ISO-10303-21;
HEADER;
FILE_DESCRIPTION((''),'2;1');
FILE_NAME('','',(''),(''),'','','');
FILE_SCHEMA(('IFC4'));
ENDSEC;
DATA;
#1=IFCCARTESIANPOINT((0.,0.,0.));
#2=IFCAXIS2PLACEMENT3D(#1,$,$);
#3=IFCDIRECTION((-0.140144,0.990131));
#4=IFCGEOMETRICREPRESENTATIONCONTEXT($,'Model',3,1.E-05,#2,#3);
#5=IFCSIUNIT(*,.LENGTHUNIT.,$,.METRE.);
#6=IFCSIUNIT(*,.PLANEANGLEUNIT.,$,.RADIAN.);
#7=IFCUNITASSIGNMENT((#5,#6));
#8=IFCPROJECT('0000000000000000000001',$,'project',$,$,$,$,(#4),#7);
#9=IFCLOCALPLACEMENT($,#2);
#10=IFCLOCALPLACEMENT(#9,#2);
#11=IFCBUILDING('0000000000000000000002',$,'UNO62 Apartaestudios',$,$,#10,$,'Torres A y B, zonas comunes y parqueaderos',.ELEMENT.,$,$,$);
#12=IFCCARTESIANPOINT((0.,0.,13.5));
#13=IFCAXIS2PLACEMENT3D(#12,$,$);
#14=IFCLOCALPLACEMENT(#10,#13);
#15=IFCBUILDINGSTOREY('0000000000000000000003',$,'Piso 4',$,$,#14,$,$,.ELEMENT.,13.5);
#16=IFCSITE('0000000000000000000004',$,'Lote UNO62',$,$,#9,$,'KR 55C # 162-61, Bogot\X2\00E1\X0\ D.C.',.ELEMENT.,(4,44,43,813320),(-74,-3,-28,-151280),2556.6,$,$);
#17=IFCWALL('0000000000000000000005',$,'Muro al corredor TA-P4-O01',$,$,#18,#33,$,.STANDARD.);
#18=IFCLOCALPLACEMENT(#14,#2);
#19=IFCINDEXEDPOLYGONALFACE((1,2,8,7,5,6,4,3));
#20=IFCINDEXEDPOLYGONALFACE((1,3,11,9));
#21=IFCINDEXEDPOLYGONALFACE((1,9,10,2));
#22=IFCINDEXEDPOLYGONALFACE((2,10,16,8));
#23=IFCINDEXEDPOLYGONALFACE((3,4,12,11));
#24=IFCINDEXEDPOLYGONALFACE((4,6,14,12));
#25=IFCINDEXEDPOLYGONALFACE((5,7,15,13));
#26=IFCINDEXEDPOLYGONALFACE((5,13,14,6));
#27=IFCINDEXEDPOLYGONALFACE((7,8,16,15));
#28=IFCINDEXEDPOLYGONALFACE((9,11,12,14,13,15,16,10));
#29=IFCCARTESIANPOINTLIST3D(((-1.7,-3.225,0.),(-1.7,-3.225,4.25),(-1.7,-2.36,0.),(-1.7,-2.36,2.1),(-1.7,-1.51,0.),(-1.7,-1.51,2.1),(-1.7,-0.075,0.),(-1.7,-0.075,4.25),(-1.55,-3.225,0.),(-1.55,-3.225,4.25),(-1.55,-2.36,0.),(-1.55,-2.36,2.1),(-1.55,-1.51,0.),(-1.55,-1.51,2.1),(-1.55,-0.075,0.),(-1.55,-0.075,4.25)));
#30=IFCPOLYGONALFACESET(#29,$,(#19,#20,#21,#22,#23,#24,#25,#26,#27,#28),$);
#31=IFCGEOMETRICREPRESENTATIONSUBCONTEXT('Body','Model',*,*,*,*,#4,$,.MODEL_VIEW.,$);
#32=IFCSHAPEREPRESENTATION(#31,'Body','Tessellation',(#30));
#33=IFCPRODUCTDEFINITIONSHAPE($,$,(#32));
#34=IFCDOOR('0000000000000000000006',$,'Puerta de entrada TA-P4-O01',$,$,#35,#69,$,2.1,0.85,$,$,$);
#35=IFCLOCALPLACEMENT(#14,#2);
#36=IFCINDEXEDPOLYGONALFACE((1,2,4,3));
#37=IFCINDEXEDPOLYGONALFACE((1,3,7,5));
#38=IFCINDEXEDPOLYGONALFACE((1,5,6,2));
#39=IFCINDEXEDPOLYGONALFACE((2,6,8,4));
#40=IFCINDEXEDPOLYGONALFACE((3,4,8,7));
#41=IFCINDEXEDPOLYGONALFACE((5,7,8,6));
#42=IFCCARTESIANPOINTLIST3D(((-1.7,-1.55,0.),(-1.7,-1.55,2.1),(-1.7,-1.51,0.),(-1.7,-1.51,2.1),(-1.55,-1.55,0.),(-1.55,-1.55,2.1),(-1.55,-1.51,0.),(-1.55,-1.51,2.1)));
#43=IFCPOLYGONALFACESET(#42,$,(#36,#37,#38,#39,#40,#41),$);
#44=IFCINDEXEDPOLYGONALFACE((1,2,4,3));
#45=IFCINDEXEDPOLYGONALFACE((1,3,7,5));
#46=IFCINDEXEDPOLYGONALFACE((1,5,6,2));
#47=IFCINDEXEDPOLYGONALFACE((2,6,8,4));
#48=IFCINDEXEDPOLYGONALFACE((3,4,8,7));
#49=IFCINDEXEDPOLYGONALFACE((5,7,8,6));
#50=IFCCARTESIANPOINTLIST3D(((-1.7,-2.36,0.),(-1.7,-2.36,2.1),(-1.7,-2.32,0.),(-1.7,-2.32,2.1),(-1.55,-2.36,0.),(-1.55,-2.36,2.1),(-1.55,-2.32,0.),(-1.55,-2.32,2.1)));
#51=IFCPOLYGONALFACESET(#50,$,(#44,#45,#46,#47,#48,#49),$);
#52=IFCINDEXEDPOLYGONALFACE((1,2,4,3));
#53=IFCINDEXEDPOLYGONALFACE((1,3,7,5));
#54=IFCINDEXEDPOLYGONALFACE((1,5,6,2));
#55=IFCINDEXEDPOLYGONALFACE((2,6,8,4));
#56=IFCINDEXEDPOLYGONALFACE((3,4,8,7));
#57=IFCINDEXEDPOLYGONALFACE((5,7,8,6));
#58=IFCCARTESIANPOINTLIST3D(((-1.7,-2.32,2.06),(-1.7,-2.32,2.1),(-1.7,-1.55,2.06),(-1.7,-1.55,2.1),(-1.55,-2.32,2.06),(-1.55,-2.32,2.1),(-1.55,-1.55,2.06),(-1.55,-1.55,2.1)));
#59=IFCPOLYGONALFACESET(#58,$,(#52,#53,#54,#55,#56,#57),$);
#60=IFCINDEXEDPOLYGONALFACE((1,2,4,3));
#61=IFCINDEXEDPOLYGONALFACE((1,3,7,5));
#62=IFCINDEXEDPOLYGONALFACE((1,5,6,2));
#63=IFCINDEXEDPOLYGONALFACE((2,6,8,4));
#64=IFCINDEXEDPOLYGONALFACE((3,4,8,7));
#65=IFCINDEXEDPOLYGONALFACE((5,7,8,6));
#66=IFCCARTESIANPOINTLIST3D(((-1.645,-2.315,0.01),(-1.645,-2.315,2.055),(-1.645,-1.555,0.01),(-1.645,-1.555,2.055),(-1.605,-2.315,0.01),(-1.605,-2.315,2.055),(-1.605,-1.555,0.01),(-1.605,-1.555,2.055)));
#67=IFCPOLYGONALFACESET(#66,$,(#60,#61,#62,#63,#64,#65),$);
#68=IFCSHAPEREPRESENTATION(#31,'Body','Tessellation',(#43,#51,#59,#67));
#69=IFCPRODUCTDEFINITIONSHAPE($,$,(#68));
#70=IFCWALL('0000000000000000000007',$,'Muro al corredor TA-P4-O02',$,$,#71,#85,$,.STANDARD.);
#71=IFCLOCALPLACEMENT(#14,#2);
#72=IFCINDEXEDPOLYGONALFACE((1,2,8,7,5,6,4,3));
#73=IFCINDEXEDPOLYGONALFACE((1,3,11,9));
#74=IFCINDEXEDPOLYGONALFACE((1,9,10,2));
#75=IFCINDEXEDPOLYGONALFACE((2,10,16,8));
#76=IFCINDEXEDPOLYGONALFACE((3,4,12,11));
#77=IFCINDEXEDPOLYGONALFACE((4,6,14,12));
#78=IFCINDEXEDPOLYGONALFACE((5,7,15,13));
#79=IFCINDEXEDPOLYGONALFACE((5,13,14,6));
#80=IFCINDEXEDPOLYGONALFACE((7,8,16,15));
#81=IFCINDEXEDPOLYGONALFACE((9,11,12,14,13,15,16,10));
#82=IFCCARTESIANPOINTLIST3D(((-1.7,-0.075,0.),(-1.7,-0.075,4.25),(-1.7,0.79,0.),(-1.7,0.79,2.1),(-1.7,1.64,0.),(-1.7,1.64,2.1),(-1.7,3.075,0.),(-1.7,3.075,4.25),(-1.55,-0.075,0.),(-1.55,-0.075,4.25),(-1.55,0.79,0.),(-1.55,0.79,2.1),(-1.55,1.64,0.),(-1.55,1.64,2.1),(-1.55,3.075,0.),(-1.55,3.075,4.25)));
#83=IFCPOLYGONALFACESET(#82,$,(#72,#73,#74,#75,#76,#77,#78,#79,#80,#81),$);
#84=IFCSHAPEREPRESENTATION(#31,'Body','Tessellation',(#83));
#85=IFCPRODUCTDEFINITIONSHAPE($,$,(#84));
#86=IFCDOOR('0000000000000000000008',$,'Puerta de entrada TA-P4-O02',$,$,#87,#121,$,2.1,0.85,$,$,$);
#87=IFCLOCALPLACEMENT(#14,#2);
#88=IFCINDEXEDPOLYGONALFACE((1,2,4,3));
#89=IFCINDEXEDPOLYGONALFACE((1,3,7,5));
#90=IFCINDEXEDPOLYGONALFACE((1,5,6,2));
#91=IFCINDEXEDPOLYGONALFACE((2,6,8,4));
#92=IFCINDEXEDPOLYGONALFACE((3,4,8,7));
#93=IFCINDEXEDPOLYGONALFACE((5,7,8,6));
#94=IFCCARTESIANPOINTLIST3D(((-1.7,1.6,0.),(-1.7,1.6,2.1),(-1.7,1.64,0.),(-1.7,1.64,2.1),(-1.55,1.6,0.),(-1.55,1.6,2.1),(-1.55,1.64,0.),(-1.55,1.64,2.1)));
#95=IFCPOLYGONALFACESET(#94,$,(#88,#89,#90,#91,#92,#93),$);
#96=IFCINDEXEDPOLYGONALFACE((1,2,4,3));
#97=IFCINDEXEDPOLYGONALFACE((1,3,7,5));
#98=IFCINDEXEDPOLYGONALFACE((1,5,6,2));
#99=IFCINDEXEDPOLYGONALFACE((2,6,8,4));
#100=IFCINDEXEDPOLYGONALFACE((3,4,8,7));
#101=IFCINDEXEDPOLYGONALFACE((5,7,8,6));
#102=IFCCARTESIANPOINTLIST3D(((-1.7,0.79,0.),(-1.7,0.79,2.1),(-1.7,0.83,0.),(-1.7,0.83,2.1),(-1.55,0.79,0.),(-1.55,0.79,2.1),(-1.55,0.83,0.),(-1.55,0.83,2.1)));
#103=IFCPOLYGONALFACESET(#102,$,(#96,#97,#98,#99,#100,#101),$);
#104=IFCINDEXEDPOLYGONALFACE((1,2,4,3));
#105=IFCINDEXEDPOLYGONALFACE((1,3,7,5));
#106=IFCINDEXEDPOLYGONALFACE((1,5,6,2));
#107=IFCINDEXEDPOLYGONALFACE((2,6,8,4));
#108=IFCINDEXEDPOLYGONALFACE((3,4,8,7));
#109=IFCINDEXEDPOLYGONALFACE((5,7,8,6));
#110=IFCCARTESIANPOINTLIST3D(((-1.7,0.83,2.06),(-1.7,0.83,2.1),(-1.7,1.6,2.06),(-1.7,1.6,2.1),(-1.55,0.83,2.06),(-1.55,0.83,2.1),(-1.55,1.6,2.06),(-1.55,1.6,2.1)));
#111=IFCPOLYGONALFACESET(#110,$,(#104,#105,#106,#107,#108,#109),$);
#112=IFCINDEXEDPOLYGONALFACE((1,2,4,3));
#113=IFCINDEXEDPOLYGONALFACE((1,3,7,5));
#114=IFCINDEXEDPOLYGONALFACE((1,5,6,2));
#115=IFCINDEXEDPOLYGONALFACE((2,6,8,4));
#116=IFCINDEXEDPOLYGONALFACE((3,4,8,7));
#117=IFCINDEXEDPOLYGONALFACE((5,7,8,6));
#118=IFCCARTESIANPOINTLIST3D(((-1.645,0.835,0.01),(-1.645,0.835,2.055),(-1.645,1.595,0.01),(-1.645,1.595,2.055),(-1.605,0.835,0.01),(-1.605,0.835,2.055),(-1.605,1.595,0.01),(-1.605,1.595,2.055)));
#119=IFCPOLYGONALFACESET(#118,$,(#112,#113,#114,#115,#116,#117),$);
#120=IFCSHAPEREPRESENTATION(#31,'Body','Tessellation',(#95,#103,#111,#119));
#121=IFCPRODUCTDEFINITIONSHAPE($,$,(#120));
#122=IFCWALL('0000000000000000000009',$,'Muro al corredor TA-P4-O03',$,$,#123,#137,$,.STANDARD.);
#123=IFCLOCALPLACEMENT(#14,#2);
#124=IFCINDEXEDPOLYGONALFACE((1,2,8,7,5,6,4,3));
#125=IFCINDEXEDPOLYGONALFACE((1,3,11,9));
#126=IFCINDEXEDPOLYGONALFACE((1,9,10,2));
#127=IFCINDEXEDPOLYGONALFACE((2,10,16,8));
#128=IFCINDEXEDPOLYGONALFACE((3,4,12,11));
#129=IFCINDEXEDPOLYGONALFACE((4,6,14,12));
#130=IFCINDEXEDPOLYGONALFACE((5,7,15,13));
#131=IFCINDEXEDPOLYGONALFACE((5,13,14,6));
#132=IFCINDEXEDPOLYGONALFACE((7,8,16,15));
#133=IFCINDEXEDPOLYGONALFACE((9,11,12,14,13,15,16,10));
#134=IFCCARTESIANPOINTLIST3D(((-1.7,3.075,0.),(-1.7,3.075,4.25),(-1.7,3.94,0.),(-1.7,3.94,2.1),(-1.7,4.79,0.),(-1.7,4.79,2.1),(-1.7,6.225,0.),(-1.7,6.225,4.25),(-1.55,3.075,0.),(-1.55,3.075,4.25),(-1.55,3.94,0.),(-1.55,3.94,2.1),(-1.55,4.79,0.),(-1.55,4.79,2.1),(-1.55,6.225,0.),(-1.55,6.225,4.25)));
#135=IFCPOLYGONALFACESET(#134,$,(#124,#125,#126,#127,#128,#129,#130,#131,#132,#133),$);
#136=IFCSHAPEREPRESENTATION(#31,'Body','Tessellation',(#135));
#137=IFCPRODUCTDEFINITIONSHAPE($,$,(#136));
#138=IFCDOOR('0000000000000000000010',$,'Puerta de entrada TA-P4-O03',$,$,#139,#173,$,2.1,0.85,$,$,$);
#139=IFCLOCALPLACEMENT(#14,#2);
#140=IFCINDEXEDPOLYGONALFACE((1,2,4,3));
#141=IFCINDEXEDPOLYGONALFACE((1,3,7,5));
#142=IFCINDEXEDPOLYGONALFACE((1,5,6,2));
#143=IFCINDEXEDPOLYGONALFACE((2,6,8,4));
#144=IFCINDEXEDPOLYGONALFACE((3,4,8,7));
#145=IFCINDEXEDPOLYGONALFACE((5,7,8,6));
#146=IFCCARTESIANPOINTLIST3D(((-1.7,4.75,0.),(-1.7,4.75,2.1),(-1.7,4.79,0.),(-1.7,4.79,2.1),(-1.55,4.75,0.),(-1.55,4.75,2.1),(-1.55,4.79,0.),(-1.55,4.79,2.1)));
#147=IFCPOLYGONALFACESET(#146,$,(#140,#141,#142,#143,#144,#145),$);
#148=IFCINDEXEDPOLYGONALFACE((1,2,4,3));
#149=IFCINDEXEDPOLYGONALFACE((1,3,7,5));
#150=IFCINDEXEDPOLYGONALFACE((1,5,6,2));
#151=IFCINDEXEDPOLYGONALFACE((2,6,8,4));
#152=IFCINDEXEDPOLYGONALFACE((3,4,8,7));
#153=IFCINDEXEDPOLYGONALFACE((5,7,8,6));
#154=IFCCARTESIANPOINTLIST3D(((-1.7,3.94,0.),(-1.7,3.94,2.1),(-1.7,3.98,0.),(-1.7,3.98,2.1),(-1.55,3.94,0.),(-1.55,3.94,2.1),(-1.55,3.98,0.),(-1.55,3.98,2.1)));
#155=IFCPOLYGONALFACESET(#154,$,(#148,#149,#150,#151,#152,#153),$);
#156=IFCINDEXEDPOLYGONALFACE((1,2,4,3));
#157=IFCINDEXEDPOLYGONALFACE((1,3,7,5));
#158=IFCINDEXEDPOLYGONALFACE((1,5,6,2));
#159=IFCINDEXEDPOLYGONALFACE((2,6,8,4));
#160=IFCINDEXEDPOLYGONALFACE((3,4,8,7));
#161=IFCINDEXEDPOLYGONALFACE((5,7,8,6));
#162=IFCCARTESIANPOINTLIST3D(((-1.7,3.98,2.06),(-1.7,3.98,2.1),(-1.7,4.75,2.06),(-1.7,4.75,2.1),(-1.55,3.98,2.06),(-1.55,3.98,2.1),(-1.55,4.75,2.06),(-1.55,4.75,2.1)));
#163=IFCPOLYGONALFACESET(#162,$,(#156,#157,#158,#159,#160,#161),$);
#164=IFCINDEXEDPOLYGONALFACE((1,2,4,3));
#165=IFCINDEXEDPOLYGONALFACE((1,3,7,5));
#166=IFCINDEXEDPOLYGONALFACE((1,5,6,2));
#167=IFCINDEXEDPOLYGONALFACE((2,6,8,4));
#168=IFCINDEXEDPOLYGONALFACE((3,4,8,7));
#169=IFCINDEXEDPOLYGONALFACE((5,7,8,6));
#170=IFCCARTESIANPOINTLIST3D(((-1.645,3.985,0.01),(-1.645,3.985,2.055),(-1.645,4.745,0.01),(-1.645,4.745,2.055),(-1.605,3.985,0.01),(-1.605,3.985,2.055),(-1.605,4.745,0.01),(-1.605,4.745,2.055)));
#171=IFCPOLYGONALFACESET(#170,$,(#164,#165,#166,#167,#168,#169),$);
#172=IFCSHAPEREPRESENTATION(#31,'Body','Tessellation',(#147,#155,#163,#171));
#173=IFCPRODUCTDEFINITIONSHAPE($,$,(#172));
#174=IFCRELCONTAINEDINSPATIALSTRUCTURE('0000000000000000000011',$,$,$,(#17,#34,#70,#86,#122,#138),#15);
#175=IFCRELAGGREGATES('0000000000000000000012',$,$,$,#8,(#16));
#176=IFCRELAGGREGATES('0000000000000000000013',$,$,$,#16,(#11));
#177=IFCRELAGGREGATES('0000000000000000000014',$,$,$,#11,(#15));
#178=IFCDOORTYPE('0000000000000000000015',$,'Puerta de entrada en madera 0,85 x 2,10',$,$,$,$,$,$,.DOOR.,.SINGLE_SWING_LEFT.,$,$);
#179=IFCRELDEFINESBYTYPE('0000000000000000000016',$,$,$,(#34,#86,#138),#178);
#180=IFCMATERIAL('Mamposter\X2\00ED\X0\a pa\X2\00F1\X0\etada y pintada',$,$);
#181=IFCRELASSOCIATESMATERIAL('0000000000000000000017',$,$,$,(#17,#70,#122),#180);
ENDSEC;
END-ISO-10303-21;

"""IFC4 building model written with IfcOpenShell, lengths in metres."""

from ifc_helpers import new_model, si_unit, direction, frame, frame_2d, origin, place, context, subcontext, project, spatial, rectangle, extrude, source, transform, mapped, material, type_object, type_shapes, element, fill, save


model = new_model("IFC4")

# Units and contexts
model_context = context("Model", 3, precision=1e-05, world=origin(), true_north=direction((-0.140144, 0.990131)))
body_context = subcontext(model_context, "Body", "Model", "MODEL_VIEW")
ifc_project = project(units=[si_unit("LENGTHUNIT", "METRE"), si_unit("PLANEANGLEUNIT", "RADIAN")], contexts=[model_context])

# Site, building, storey
site_placement = place(None, origin())
site = spatial("IfcSite", under=ifc_project, at=site_placement, Name="Lote UNO62", LongName="KR 55C # 162-61, Bogotá D.C.", CompositionType="ELEMENT", RefLatitude=(4, 44, 43, 813320), RefLongitude=(-74, -3, -28, -151280), RefElevation=2556.6)
building_placement = place(site_placement, origin())
building = spatial("IfcBuilding", under=site, at=building_placement, Name="UNO62 Apartaestudios", LongName="Torres A y B, zonas comunes y parqueaderos", CompositionType="ELEMENT")
storey_placement = place(building_placement, frame((0.0, 0.0, 13.5)))
storey = spatial("IfcBuildingStorey", under=building, at=storey_placement, Name="Piso 4", CompositionType="ELEMENT", Elevation=13.5)

# Walls, openings, doors
ifc_material = material(Name="Mampostería pañetada y pintada")
wall_1_placement = place(storey_placement, origin())
wall_1 = element("IfcWall", 1, at=wall_1_placement, inside=storey, material=ifc_material, Name="Muro al corredor TA-P4-O01", PredefinedType="STANDARD", context=body_context, shape_type="SweptSolid", body=[
    extrude(rectangle(XDim=0.15, YDim=3.15, at=frame_2d((-1.625, -1.65))), origin(), (0.0, 0.0, 1.0), 4.25),
])
opening_1_placement = place(wall_1_placement, origin())
opening_1 = element("IfcOpeningElement", 2, at=opening_1_placement, cuts=wall_1, PredefinedType="OPENING", context=body_context, shape_type="SweptSolid", body=[
    extrude(rectangle(XDim=0.25, YDim=0.85, at=frame_2d((-1.625, -1.935))), origin(), (0.0, 0.0, 1.0), 2.1),
])
door_type = type_object("IfcDoorType", Name="Puerta de entrada en madera 0,85 x 2,10", OperationType="SINGLE_SWING_LEFT", PredefinedType="DOOR")
shared_shape = source(origin(), body_context, "Body", "SweptSolid", [
    extrude(rectangle(XDim=0.15, YDim=0.04, at=frame_2d((-0.075, 1.38))), origin(), (0.0, 0.0, 1.0), 2.1),
    extrude(rectangle(XDim=0.15, YDim=0.04, at=frame_2d((-0.075, 2.19))), origin(), (0.0, 0.0, 1.0), 2.1),
    extrude(rectangle(XDim=0.15, YDim=0.77, at=frame_2d((-0.075, 1.785))), frame((0.0, 0.0, 2.06)), (0.0, 0.0, 1.0), 0.04),
    extrude(rectangle(XDim=0.04, YDim=0.76, at=frame_2d((-0.075, 1.785))), frame((0.0, 0.0, 0.01)), (0.0, 0.0, 1.0), 2.045),
])
type_shapes(door_type, [shared_shape])
placement_1 = place(storey_placement, frame((-1.7, -0.15, 0.0), z_axis=(0.0, 0.0, 1.0), x_axis=(-1.0, 0.0, 0.0)))
door_1_placement = place(placement_1, origin())
door_1 = element("IfcDoor", 3, at=door_1_placement, inside=storey, type_object=door_type, Name="Puerta de entrada TA-P4-O01", OverallHeight=2.1, OverallWidth=0.85, context=body_context, shape_type="MappedRepresentation", body=[
    mapped(shared_shape, transform((0.0, 0.0, 0.0))),
])
fill(opening_1, door_1)
wall_2_placement = place(storey_placement, origin())
wall_2 = element("IfcWall", 4, at=wall_2_placement, inside=storey, material=ifc_material, Name="Muro al corredor TA-P4-O02", PredefinedType="STANDARD", context=body_context, shape_type="SweptSolid", body=[
    extrude(rectangle(XDim=0.15, YDim=3.15, at=frame_2d((-1.625, 1.5))), origin(), (0.0, 0.0, 1.0), 4.25),
])
opening_2_placement = place(wall_2_placement, origin())
opening_2 = element("IfcOpeningElement", 5, at=opening_2_placement, cuts=wall_2, PredefinedType="OPENING", context=body_context, shape_type="SweptSolid", body=[
    extrude(rectangle(XDim=0.25, YDim=0.85, at=frame_2d((-1.625, 1.215))), origin(), (0.0, 0.0, 1.0), 2.1),
])
placement_2 = place(storey_placement, frame((-1.7, 3.0, 0.0), z_axis=(0.0, 0.0, 1.0), x_axis=(-1.0, 0.0, 0.0)))
door_2_placement = place(placement_2, origin())
door_2 = element("IfcDoor", 6, at=door_2_placement, inside=storey, type_object=door_type, Name="Puerta de entrada TA-P4-O02", OverallHeight=2.1, OverallWidth=0.85, context=body_context, shape_type="MappedRepresentation", body=[
    mapped(shared_shape, transform((0.0, 0.0, 0.0))),
])
fill(opening_2, door_2)
wall_3_placement = place(storey_placement, origin())
wall_3 = element("IfcWall", 7, at=wall_3_placement, inside=storey, material=ifc_material, Name="Muro al corredor TA-P4-O03", PredefinedType="STANDARD", context=body_context, shape_type="SweptSolid", body=[
    extrude(rectangle(XDim=0.15, YDim=3.15, at=frame_2d((-1.625, 4.65))), origin(), (0.0, 0.0, 1.0), 4.25),
])
opening_3_placement = place(wall_3_placement, origin())
opening_3 = element("IfcOpeningElement", 8, at=opening_3_placement, cuts=wall_3, PredefinedType="OPENING", context=body_context, shape_type="SweptSolid", body=[
    extrude(rectangle(XDim=0.25, YDim=0.85, at=frame_2d((-1.625, 4.365))), origin(), (0.0, 0.0, 1.0), 2.1),
])
placement_3 = place(storey_placement, frame((-1.7, 6.15, 0.0), z_axis=(0.0, 0.0, 1.0), x_axis=(-1.0, 0.0, 0.0)))
door_3_placement = place(placement_3, origin())
door_3 = element("IfcDoor", 9, at=door_3_placement, inside=storey, type_object=door_type, Name="Puerta de entrada TA-P4-O03", OverallHeight=2.1, OverallWidth=0.85, context=body_context, shape_type="MappedRepresentation", body=[
    mapped(shared_shape, transform((0.0, 0.0, 0.0))),
])
fill(opening_3, door_3)

save(model, "model.ifc")
